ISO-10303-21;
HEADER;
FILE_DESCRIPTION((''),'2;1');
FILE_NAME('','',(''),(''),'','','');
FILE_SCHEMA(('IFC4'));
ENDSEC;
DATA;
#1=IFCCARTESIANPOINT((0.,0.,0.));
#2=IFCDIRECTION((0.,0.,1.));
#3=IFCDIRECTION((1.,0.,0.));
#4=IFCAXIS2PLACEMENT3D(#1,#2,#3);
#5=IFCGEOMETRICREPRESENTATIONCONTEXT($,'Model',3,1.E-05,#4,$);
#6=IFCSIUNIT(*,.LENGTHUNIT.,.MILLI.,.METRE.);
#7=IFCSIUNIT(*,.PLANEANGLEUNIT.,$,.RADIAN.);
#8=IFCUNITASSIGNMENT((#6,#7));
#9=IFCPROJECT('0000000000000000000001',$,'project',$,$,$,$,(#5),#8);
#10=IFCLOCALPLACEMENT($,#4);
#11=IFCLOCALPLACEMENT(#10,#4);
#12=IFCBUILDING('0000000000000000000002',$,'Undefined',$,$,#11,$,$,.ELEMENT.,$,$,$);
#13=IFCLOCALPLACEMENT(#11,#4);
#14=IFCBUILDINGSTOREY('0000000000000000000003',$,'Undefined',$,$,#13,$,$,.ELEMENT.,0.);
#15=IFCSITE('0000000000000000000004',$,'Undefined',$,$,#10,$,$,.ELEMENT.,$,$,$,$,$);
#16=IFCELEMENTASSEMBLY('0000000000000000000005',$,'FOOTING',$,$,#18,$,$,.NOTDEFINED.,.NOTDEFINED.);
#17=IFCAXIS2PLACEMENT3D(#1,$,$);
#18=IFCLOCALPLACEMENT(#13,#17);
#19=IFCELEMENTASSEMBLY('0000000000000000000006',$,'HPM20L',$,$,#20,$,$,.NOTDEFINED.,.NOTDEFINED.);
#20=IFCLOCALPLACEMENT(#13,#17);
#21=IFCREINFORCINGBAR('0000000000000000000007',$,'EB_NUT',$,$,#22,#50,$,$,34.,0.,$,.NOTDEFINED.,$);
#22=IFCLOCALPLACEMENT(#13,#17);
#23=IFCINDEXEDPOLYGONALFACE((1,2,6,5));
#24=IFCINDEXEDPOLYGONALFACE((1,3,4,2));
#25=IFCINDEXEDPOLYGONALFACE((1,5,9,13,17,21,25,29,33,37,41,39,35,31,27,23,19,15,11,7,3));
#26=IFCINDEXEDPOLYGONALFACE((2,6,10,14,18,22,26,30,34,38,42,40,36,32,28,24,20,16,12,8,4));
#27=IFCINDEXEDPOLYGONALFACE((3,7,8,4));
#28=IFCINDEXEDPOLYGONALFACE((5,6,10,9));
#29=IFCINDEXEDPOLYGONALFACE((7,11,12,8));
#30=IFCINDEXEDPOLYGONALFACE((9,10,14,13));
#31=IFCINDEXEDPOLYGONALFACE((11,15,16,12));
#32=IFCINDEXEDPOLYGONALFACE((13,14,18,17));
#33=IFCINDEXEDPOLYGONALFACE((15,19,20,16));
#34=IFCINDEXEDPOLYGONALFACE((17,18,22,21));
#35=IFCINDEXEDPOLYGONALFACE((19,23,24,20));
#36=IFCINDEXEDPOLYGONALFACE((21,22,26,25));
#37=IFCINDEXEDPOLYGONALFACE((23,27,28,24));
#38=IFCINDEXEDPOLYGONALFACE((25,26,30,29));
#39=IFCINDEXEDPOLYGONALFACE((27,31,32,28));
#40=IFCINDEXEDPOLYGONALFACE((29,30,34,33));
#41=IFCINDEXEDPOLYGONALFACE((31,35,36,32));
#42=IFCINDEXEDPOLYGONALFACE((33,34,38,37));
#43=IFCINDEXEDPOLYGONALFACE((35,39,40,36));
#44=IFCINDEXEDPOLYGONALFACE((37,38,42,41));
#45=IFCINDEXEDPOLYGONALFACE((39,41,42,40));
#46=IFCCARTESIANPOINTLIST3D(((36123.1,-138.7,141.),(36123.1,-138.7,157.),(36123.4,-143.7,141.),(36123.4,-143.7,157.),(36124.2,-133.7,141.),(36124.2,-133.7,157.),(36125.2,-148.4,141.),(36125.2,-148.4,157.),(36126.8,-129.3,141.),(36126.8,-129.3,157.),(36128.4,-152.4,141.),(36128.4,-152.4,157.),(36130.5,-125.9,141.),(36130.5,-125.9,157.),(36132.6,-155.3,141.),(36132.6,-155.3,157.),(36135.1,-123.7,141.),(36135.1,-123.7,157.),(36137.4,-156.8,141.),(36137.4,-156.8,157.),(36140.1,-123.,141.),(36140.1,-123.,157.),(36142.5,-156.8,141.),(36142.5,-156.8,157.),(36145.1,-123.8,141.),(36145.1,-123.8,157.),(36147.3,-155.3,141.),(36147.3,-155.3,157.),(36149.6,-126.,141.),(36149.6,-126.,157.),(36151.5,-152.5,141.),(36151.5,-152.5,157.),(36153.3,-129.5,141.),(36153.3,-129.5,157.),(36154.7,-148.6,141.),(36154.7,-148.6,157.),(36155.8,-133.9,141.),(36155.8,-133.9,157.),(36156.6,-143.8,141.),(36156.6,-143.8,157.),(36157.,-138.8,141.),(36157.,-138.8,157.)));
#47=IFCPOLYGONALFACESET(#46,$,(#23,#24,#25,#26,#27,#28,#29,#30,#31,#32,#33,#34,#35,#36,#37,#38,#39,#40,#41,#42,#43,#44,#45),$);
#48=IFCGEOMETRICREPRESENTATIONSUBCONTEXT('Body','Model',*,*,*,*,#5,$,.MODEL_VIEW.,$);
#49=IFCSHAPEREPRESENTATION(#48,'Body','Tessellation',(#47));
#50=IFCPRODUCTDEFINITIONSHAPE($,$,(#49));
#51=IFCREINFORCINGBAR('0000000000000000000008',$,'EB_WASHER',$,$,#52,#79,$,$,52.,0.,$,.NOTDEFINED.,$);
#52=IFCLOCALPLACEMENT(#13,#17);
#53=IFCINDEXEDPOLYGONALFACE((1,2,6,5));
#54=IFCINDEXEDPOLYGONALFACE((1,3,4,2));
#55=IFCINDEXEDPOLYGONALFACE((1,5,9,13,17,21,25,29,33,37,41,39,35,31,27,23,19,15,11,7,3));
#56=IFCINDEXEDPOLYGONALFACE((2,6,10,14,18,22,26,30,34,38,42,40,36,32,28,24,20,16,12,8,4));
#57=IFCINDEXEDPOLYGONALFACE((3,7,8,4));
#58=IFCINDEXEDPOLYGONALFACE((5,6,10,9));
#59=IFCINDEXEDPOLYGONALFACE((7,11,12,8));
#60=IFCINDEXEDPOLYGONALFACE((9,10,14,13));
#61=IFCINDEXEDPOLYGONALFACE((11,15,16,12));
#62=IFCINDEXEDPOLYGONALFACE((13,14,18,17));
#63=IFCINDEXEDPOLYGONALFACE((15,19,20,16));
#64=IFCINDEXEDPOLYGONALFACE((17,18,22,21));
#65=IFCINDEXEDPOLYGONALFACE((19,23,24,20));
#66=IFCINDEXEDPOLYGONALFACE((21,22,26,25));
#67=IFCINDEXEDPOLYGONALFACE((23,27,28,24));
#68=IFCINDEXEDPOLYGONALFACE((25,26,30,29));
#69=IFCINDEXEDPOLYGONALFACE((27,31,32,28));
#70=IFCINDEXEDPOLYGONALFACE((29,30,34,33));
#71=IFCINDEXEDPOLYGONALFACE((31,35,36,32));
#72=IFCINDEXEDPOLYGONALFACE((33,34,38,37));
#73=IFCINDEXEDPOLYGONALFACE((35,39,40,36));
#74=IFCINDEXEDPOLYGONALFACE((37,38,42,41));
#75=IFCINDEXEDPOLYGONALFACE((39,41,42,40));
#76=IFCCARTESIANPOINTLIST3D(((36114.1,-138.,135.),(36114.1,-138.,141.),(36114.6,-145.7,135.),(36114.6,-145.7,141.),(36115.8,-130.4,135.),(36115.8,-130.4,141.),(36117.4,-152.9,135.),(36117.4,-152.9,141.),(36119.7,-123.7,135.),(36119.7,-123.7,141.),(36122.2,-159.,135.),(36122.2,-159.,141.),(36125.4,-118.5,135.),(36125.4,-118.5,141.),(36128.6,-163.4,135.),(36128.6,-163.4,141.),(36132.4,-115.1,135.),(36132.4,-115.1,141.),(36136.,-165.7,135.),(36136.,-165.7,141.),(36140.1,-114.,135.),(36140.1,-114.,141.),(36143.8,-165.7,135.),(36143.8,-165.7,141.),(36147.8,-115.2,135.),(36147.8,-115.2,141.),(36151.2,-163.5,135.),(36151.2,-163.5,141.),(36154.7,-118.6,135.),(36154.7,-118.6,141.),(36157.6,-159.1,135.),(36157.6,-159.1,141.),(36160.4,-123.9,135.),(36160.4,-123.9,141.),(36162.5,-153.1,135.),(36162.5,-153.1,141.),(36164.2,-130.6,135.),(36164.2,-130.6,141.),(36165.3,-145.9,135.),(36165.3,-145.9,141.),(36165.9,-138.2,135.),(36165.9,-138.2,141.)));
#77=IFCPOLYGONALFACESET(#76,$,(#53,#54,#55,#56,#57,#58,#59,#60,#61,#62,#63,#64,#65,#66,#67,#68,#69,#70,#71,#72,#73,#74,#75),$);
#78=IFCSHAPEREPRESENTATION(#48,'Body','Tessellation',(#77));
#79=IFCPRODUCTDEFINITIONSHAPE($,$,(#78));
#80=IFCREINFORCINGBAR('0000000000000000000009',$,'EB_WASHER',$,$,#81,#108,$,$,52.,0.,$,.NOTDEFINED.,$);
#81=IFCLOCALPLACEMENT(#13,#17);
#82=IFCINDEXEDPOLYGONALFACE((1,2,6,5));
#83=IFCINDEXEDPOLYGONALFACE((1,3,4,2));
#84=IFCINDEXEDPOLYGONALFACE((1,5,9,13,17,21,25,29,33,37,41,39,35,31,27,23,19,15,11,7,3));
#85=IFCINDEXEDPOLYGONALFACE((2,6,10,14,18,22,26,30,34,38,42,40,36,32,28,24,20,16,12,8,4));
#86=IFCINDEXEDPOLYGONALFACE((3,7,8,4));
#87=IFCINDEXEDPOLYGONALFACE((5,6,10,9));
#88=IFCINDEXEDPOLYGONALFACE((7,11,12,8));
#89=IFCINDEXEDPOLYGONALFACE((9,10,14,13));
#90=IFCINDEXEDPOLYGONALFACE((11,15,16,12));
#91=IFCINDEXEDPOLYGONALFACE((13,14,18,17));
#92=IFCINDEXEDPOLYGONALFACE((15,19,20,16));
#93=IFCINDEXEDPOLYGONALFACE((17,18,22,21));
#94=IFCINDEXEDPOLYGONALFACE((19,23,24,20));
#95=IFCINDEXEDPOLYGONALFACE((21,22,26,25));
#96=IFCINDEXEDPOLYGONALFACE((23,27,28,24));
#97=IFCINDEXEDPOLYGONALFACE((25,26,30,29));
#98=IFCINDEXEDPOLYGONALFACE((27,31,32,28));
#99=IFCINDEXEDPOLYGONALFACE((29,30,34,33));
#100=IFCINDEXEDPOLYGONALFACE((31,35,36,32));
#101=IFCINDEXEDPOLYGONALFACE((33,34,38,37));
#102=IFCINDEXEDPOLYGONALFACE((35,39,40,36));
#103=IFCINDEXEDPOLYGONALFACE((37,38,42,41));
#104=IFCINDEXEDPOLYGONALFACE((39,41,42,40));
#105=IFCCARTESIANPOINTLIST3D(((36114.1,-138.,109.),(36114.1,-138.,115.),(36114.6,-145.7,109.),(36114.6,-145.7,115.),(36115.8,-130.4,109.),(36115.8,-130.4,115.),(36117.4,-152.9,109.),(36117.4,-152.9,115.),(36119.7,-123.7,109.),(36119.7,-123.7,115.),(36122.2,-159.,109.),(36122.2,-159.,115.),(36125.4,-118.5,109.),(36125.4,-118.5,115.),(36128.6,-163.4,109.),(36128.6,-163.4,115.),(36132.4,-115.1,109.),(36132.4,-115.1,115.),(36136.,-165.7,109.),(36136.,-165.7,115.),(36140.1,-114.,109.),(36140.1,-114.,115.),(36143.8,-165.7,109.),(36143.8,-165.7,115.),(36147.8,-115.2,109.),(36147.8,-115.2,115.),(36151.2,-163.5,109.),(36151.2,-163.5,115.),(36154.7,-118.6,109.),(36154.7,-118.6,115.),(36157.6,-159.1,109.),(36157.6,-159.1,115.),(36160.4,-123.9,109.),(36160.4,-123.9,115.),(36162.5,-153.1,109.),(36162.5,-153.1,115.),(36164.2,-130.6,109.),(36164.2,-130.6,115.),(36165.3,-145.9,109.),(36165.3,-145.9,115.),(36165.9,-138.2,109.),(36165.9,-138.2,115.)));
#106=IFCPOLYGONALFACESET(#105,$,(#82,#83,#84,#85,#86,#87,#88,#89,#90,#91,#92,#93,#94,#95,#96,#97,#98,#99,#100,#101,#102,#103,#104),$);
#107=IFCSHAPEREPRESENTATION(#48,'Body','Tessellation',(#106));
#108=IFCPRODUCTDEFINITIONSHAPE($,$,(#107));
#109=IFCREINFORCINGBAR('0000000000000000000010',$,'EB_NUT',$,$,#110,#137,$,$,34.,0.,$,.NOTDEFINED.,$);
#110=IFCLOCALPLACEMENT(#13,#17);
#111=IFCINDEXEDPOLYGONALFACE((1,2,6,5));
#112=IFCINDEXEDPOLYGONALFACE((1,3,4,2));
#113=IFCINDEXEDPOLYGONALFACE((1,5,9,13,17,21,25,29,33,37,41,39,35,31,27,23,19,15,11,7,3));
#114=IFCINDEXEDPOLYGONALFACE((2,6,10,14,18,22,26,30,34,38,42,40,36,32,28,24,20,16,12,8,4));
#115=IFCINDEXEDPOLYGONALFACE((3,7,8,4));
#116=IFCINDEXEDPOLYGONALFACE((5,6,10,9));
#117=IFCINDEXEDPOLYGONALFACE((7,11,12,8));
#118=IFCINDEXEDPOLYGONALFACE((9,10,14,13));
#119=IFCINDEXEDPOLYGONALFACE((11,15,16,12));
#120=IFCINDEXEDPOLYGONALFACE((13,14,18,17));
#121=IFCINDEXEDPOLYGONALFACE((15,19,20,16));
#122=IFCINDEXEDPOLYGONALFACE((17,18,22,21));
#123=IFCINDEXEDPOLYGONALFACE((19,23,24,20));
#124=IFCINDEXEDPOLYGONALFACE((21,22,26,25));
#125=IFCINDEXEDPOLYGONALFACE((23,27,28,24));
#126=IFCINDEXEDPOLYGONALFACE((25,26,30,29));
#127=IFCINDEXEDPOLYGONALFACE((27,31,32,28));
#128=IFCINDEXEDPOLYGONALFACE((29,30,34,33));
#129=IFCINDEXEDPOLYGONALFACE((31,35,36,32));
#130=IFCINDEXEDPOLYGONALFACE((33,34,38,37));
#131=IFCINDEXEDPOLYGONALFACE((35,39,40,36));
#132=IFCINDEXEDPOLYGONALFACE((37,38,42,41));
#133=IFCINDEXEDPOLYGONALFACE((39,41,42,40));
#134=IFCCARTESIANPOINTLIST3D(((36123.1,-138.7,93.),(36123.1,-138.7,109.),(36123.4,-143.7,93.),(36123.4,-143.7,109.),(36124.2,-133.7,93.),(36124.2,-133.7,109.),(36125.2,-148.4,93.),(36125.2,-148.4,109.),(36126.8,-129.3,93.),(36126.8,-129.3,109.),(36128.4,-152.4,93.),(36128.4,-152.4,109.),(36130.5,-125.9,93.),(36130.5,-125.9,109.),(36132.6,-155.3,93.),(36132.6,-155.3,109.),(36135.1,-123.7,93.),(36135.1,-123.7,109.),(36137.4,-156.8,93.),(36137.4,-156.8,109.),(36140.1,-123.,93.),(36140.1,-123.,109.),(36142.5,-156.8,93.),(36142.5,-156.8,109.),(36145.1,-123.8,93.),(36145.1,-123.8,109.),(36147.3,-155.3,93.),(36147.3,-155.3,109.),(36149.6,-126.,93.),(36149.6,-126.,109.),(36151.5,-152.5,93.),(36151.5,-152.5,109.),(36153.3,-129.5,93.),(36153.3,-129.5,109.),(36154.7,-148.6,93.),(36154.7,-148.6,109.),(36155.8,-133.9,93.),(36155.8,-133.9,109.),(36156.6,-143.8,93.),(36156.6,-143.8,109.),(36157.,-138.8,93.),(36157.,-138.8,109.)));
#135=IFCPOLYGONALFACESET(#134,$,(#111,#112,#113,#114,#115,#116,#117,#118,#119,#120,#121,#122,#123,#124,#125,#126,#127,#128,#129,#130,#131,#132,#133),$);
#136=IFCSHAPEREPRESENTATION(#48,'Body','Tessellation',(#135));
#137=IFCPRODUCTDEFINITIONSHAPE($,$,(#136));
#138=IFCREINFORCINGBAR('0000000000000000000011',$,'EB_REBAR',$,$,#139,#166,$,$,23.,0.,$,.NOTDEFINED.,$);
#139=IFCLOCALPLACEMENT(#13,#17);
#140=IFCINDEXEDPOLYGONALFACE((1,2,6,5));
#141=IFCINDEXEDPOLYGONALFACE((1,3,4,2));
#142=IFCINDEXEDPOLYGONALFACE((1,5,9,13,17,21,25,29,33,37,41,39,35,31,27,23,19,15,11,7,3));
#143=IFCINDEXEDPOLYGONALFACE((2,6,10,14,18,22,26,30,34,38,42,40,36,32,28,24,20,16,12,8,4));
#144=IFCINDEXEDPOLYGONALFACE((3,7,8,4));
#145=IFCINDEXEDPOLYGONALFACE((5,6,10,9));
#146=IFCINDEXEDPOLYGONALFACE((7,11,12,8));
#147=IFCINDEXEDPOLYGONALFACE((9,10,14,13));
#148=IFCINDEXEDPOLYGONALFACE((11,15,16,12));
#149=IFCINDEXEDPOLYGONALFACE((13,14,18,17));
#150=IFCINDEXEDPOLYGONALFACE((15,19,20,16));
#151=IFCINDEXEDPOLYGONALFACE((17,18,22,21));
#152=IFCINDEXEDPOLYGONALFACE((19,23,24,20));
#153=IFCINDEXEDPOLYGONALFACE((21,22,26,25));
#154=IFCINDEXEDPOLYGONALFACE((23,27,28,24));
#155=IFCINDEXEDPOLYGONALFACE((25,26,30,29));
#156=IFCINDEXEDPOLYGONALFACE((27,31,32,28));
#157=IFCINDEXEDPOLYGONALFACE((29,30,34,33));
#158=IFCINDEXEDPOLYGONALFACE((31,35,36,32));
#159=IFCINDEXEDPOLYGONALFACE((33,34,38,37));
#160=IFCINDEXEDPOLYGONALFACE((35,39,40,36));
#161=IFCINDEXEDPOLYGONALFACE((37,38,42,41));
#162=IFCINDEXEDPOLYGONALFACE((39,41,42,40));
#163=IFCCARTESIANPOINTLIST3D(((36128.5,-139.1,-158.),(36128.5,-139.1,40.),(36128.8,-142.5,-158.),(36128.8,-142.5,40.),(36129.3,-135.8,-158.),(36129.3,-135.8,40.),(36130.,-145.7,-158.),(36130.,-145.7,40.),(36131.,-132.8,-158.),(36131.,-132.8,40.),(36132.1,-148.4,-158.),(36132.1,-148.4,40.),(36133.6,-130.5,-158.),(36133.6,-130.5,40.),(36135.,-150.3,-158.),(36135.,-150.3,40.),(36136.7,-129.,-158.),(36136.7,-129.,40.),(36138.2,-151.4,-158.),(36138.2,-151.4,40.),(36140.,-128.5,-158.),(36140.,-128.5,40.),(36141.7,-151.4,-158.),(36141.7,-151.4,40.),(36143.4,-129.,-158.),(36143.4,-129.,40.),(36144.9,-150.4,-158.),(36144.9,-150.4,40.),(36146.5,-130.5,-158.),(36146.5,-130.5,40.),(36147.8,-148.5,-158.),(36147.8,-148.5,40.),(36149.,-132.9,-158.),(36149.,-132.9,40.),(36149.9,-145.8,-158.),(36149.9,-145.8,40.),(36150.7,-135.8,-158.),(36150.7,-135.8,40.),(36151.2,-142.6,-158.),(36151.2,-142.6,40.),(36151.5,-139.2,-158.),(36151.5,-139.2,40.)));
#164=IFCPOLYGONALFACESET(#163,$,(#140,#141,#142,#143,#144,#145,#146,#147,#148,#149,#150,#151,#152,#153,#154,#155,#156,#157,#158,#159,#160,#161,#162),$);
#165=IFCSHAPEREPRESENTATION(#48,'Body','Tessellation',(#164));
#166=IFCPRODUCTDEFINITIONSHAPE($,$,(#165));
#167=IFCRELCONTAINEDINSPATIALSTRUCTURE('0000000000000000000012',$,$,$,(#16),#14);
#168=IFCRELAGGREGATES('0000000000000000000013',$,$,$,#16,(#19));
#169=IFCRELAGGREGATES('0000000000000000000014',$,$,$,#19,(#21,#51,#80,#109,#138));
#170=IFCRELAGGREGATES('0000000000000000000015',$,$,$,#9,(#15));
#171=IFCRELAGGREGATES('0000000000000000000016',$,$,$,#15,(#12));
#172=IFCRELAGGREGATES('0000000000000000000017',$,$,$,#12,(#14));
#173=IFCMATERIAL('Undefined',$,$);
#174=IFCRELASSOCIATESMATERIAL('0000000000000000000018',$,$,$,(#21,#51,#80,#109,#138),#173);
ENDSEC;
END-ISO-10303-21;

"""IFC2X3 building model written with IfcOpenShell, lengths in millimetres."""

from ifc_helpers import new_model, entity, si_unit, frame, origin_with_axes, place, context, subcontext, project, spatial, source, transform, mapped, material, element, aggregate, save


model = new_model("IFC2X3")

# Units and contexts
model_context = context("Model", 3, precision=1e-05, world=origin_with_axes())
body_context = subcontext(model_context, "Body", "Model", "MODEL_VIEW")
ifc_project = project(units=[si_unit("LENGTHUNIT", "METRE", prefix="MILLI"), si_unit("PLANEANGLEUNIT", "RADIAN")], contexts=[model_context])

# Site, building, storey
site_placement = place(None, origin_with_axes())
site = spatial("IfcSite", under=ifc_project, at=site_placement, Name="Undefined", CompositionType="ELEMENT")
building_placement = place(site_placement, origin_with_axes())
building = spatial("IfcBuilding", under=site, at=building_placement, Name="Undefined", CompositionType="ELEMENT")
storey_placement = place(building_placement, origin_with_axes())
storey = spatial("IfcBuildingStorey", under=building, at=storey_placement, Name="Undefined", CompositionType="ELEMENT", Elevation=0.0)

# Element assembly
assembly_1_placement = place(storey_placement, origin_with_axes())
assembly_1 = element("IfcElementAssembly", 1, at=assembly_1_placement, inside=storey, Name="FOOTING", AssemblyPlace="NOTDEFINED", PredefinedType="NOTDEFINED")

# Shared definitions
ifc_material_1 = material(Name="Undefined")

# Element assembly
assembly_2_placement = place(assembly_1_placement, origin_with_axes())
assembly_2 = element("IfcElementAssembly", 2, at=assembly_2_placement, Name="HPM20L", AssemblyPlace="NOTDEFINED", PredefinedType="NOTDEFINED")
aggregate(assembly_1, [assembly_2])

# Reinforcing bars
shared_shape_1 = source(origin_with_axes(), body_context, "Body", "AdvancedSweptSolid", [
    entity("IfcSweptDiskSolid", entity("IfcTrimmedCurve", entity("IfcLine", entity("IfcCartesianPoint", [0.0, 0.0, 0.0]), entity("IfcVector", entity("IfcDirection", [1.0, 0.0, 0.0]), 1.0)), [entity("IfcParameterValue", 0.0)], [entity("IfcParameterValue", 16.0)], True, "PARAMETER"), 17.0, None, 0.0, 16.0),
])
reinforcing_bar_1_placement = place(assembly_2_placement, frame((36140.0, -140.0, 157.0), z_axis=(0.003874, 0.999992, 0.0), x_axis=(0.0, 0.0, -1.0)))
reinforcing_bar_1 = element("IfcReinforcingBar", 3, at=reinforcing_bar_1_placement, material=ifc_material_1, Name="EB_NUT", BarRole="NOTDEFINED", CrossSectionArea=0.0, NominalDiameter=34.0, context=body_context, shape_type="MappedRepresentation", body=[
    mapped(shared_shape_1, transform((0.0, 0.0, 0.0))),
])
shared_shape_2 = source(origin_with_axes(), body_context, "Body", "AdvancedSweptSolid", [
    entity("IfcSweptDiskSolid", entity("IfcTrimmedCurve", entity("IfcLine", entity("IfcCartesianPoint", [0.0, 0.0, 0.0]), entity("IfcVector", entity("IfcDirection", [1.0, 0.0, 0.0]), 1.0)), [entity("IfcParameterValue", 0.0)], [entity("IfcParameterValue", 6.0)], True, "PARAMETER"), 26.0, None, 0.0, 6.0),
])
reinforcing_bar_2_placement = place(assembly_2_placement, frame((36140.0, -140.0, 141.0), z_axis=(0.003874, 0.999992, 0.0), x_axis=(0.0, 0.0, -1.0)))
reinforcing_bar_2 = element("IfcReinforcingBar", 4, at=reinforcing_bar_2_placement, material=ifc_material_1, Name="EB_WASHER", BarRole="NOTDEFINED", CrossSectionArea=0.0, NominalDiameter=52.0, context=body_context, shape_type="MappedRepresentation", body=[
    mapped(shared_shape_2, transform((0.0, 0.0, 0.0))),
])
shared_shape_3 = source(origin_with_axes(), body_context, "Body", "AdvancedSweptSolid", [
    entity("IfcSweptDiskSolid", entity("IfcTrimmedCurve", entity("IfcLine", entity("IfcCartesianPoint", [0.0, 0.0, 0.0]), entity("IfcVector", entity("IfcDirection", [1.0, 0.0, 0.0]), 1.0)), [entity("IfcParameterValue", 0.0)], [entity("IfcParameterValue", 6.0)], True, "PARAMETER"), 26.0, None, 0.0, 6.0),
])
reinforcing_bar_3_placement = place(assembly_2_placement, frame((36140.0, -140.0, 115.0), z_axis=(0.003874, 0.999992, 0.0), x_axis=(0.0, 0.0, -1.0)))
reinforcing_bar_3 = element("IfcReinforcingBar", 5, at=reinforcing_bar_3_placement, material=ifc_material_1, Name="EB_WASHER", BarRole="NOTDEFINED", CrossSectionArea=0.0, NominalDiameter=52.0, context=body_context, shape_type="MappedRepresentation", body=[
    mapped(shared_shape_3, transform((0.0, 0.0, 0.0))),
])
shared_shape_4 = source(origin_with_axes(), body_context, "Body", "AdvancedSweptSolid", [
    entity("IfcSweptDiskSolid", entity("IfcTrimmedCurve", entity("IfcLine", entity("IfcCartesianPoint", [0.0, 0.0, 0.0]), entity("IfcVector", entity("IfcDirection", [1.0, 0.0, 0.0]), 1.0)), [entity("IfcParameterValue", 0.0)], [entity("IfcParameterValue", 16.0)], True, "PARAMETER"), 17.0, None, 0.0, 16.0),
])
reinforcing_bar_4_placement = place(assembly_2_placement, frame((36140.0, -140.0, 109.0), z_axis=(0.003874, 0.999992, 0.0), x_axis=(0.0, 0.0, -1.0)))
reinforcing_bar_4 = element("IfcReinforcingBar", 6, at=reinforcing_bar_4_placement, material=ifc_material_1, Name="EB_NUT", BarRole="NOTDEFINED", CrossSectionArea=0.0, NominalDiameter=34.0, context=body_context, shape_type="MappedRepresentation", body=[
    mapped(shared_shape_4, transform((0.0, 0.0, 0.0))),
])
shared_shape_5 = source(origin_with_axes(), body_context, "Body", "AdvancedSweptSolid", [
    entity("IfcSweptDiskSolid", entity("IfcTrimmedCurve", entity("IfcLine", entity("IfcCartesianPoint", [0.0, 0.0, 0.0]), entity("IfcVector", entity("IfcDirection", [1.0, 0.0, 0.0]), 1.0)), [entity("IfcParameterValue", 0.0)], [entity("IfcParameterValue", 198.0)], True, "PARAMETER"), 11.5, None, 0.0, 198.0),
])
reinforcing_bar_5_placement = place(assembly_2_placement, frame((36140.0, -140.0, 40.0), z_axis=(0.003874, 0.999992, 0.0), x_axis=(0.0, 0.0, -1.0)))
reinforcing_bar_5 = element("IfcReinforcingBar", 7, at=reinforcing_bar_5_placement, material=ifc_material_1, Name="EB_REBAR", BarRole="NOTDEFINED", CrossSectionArea=0.0, NominalDiameter=23.0, context=body_context, shape_type="MappedRepresentation", body=[
    mapped(shared_shape_5, transform((0.0, 0.0, 0.0))),
])
aggregate(assembly_2, [reinforcing_bar_1, reinforcing_bar_2, reinforcing_bar_3, reinforcing_bar_4, reinforcing_bar_5])

save(model, "model.ifc")
